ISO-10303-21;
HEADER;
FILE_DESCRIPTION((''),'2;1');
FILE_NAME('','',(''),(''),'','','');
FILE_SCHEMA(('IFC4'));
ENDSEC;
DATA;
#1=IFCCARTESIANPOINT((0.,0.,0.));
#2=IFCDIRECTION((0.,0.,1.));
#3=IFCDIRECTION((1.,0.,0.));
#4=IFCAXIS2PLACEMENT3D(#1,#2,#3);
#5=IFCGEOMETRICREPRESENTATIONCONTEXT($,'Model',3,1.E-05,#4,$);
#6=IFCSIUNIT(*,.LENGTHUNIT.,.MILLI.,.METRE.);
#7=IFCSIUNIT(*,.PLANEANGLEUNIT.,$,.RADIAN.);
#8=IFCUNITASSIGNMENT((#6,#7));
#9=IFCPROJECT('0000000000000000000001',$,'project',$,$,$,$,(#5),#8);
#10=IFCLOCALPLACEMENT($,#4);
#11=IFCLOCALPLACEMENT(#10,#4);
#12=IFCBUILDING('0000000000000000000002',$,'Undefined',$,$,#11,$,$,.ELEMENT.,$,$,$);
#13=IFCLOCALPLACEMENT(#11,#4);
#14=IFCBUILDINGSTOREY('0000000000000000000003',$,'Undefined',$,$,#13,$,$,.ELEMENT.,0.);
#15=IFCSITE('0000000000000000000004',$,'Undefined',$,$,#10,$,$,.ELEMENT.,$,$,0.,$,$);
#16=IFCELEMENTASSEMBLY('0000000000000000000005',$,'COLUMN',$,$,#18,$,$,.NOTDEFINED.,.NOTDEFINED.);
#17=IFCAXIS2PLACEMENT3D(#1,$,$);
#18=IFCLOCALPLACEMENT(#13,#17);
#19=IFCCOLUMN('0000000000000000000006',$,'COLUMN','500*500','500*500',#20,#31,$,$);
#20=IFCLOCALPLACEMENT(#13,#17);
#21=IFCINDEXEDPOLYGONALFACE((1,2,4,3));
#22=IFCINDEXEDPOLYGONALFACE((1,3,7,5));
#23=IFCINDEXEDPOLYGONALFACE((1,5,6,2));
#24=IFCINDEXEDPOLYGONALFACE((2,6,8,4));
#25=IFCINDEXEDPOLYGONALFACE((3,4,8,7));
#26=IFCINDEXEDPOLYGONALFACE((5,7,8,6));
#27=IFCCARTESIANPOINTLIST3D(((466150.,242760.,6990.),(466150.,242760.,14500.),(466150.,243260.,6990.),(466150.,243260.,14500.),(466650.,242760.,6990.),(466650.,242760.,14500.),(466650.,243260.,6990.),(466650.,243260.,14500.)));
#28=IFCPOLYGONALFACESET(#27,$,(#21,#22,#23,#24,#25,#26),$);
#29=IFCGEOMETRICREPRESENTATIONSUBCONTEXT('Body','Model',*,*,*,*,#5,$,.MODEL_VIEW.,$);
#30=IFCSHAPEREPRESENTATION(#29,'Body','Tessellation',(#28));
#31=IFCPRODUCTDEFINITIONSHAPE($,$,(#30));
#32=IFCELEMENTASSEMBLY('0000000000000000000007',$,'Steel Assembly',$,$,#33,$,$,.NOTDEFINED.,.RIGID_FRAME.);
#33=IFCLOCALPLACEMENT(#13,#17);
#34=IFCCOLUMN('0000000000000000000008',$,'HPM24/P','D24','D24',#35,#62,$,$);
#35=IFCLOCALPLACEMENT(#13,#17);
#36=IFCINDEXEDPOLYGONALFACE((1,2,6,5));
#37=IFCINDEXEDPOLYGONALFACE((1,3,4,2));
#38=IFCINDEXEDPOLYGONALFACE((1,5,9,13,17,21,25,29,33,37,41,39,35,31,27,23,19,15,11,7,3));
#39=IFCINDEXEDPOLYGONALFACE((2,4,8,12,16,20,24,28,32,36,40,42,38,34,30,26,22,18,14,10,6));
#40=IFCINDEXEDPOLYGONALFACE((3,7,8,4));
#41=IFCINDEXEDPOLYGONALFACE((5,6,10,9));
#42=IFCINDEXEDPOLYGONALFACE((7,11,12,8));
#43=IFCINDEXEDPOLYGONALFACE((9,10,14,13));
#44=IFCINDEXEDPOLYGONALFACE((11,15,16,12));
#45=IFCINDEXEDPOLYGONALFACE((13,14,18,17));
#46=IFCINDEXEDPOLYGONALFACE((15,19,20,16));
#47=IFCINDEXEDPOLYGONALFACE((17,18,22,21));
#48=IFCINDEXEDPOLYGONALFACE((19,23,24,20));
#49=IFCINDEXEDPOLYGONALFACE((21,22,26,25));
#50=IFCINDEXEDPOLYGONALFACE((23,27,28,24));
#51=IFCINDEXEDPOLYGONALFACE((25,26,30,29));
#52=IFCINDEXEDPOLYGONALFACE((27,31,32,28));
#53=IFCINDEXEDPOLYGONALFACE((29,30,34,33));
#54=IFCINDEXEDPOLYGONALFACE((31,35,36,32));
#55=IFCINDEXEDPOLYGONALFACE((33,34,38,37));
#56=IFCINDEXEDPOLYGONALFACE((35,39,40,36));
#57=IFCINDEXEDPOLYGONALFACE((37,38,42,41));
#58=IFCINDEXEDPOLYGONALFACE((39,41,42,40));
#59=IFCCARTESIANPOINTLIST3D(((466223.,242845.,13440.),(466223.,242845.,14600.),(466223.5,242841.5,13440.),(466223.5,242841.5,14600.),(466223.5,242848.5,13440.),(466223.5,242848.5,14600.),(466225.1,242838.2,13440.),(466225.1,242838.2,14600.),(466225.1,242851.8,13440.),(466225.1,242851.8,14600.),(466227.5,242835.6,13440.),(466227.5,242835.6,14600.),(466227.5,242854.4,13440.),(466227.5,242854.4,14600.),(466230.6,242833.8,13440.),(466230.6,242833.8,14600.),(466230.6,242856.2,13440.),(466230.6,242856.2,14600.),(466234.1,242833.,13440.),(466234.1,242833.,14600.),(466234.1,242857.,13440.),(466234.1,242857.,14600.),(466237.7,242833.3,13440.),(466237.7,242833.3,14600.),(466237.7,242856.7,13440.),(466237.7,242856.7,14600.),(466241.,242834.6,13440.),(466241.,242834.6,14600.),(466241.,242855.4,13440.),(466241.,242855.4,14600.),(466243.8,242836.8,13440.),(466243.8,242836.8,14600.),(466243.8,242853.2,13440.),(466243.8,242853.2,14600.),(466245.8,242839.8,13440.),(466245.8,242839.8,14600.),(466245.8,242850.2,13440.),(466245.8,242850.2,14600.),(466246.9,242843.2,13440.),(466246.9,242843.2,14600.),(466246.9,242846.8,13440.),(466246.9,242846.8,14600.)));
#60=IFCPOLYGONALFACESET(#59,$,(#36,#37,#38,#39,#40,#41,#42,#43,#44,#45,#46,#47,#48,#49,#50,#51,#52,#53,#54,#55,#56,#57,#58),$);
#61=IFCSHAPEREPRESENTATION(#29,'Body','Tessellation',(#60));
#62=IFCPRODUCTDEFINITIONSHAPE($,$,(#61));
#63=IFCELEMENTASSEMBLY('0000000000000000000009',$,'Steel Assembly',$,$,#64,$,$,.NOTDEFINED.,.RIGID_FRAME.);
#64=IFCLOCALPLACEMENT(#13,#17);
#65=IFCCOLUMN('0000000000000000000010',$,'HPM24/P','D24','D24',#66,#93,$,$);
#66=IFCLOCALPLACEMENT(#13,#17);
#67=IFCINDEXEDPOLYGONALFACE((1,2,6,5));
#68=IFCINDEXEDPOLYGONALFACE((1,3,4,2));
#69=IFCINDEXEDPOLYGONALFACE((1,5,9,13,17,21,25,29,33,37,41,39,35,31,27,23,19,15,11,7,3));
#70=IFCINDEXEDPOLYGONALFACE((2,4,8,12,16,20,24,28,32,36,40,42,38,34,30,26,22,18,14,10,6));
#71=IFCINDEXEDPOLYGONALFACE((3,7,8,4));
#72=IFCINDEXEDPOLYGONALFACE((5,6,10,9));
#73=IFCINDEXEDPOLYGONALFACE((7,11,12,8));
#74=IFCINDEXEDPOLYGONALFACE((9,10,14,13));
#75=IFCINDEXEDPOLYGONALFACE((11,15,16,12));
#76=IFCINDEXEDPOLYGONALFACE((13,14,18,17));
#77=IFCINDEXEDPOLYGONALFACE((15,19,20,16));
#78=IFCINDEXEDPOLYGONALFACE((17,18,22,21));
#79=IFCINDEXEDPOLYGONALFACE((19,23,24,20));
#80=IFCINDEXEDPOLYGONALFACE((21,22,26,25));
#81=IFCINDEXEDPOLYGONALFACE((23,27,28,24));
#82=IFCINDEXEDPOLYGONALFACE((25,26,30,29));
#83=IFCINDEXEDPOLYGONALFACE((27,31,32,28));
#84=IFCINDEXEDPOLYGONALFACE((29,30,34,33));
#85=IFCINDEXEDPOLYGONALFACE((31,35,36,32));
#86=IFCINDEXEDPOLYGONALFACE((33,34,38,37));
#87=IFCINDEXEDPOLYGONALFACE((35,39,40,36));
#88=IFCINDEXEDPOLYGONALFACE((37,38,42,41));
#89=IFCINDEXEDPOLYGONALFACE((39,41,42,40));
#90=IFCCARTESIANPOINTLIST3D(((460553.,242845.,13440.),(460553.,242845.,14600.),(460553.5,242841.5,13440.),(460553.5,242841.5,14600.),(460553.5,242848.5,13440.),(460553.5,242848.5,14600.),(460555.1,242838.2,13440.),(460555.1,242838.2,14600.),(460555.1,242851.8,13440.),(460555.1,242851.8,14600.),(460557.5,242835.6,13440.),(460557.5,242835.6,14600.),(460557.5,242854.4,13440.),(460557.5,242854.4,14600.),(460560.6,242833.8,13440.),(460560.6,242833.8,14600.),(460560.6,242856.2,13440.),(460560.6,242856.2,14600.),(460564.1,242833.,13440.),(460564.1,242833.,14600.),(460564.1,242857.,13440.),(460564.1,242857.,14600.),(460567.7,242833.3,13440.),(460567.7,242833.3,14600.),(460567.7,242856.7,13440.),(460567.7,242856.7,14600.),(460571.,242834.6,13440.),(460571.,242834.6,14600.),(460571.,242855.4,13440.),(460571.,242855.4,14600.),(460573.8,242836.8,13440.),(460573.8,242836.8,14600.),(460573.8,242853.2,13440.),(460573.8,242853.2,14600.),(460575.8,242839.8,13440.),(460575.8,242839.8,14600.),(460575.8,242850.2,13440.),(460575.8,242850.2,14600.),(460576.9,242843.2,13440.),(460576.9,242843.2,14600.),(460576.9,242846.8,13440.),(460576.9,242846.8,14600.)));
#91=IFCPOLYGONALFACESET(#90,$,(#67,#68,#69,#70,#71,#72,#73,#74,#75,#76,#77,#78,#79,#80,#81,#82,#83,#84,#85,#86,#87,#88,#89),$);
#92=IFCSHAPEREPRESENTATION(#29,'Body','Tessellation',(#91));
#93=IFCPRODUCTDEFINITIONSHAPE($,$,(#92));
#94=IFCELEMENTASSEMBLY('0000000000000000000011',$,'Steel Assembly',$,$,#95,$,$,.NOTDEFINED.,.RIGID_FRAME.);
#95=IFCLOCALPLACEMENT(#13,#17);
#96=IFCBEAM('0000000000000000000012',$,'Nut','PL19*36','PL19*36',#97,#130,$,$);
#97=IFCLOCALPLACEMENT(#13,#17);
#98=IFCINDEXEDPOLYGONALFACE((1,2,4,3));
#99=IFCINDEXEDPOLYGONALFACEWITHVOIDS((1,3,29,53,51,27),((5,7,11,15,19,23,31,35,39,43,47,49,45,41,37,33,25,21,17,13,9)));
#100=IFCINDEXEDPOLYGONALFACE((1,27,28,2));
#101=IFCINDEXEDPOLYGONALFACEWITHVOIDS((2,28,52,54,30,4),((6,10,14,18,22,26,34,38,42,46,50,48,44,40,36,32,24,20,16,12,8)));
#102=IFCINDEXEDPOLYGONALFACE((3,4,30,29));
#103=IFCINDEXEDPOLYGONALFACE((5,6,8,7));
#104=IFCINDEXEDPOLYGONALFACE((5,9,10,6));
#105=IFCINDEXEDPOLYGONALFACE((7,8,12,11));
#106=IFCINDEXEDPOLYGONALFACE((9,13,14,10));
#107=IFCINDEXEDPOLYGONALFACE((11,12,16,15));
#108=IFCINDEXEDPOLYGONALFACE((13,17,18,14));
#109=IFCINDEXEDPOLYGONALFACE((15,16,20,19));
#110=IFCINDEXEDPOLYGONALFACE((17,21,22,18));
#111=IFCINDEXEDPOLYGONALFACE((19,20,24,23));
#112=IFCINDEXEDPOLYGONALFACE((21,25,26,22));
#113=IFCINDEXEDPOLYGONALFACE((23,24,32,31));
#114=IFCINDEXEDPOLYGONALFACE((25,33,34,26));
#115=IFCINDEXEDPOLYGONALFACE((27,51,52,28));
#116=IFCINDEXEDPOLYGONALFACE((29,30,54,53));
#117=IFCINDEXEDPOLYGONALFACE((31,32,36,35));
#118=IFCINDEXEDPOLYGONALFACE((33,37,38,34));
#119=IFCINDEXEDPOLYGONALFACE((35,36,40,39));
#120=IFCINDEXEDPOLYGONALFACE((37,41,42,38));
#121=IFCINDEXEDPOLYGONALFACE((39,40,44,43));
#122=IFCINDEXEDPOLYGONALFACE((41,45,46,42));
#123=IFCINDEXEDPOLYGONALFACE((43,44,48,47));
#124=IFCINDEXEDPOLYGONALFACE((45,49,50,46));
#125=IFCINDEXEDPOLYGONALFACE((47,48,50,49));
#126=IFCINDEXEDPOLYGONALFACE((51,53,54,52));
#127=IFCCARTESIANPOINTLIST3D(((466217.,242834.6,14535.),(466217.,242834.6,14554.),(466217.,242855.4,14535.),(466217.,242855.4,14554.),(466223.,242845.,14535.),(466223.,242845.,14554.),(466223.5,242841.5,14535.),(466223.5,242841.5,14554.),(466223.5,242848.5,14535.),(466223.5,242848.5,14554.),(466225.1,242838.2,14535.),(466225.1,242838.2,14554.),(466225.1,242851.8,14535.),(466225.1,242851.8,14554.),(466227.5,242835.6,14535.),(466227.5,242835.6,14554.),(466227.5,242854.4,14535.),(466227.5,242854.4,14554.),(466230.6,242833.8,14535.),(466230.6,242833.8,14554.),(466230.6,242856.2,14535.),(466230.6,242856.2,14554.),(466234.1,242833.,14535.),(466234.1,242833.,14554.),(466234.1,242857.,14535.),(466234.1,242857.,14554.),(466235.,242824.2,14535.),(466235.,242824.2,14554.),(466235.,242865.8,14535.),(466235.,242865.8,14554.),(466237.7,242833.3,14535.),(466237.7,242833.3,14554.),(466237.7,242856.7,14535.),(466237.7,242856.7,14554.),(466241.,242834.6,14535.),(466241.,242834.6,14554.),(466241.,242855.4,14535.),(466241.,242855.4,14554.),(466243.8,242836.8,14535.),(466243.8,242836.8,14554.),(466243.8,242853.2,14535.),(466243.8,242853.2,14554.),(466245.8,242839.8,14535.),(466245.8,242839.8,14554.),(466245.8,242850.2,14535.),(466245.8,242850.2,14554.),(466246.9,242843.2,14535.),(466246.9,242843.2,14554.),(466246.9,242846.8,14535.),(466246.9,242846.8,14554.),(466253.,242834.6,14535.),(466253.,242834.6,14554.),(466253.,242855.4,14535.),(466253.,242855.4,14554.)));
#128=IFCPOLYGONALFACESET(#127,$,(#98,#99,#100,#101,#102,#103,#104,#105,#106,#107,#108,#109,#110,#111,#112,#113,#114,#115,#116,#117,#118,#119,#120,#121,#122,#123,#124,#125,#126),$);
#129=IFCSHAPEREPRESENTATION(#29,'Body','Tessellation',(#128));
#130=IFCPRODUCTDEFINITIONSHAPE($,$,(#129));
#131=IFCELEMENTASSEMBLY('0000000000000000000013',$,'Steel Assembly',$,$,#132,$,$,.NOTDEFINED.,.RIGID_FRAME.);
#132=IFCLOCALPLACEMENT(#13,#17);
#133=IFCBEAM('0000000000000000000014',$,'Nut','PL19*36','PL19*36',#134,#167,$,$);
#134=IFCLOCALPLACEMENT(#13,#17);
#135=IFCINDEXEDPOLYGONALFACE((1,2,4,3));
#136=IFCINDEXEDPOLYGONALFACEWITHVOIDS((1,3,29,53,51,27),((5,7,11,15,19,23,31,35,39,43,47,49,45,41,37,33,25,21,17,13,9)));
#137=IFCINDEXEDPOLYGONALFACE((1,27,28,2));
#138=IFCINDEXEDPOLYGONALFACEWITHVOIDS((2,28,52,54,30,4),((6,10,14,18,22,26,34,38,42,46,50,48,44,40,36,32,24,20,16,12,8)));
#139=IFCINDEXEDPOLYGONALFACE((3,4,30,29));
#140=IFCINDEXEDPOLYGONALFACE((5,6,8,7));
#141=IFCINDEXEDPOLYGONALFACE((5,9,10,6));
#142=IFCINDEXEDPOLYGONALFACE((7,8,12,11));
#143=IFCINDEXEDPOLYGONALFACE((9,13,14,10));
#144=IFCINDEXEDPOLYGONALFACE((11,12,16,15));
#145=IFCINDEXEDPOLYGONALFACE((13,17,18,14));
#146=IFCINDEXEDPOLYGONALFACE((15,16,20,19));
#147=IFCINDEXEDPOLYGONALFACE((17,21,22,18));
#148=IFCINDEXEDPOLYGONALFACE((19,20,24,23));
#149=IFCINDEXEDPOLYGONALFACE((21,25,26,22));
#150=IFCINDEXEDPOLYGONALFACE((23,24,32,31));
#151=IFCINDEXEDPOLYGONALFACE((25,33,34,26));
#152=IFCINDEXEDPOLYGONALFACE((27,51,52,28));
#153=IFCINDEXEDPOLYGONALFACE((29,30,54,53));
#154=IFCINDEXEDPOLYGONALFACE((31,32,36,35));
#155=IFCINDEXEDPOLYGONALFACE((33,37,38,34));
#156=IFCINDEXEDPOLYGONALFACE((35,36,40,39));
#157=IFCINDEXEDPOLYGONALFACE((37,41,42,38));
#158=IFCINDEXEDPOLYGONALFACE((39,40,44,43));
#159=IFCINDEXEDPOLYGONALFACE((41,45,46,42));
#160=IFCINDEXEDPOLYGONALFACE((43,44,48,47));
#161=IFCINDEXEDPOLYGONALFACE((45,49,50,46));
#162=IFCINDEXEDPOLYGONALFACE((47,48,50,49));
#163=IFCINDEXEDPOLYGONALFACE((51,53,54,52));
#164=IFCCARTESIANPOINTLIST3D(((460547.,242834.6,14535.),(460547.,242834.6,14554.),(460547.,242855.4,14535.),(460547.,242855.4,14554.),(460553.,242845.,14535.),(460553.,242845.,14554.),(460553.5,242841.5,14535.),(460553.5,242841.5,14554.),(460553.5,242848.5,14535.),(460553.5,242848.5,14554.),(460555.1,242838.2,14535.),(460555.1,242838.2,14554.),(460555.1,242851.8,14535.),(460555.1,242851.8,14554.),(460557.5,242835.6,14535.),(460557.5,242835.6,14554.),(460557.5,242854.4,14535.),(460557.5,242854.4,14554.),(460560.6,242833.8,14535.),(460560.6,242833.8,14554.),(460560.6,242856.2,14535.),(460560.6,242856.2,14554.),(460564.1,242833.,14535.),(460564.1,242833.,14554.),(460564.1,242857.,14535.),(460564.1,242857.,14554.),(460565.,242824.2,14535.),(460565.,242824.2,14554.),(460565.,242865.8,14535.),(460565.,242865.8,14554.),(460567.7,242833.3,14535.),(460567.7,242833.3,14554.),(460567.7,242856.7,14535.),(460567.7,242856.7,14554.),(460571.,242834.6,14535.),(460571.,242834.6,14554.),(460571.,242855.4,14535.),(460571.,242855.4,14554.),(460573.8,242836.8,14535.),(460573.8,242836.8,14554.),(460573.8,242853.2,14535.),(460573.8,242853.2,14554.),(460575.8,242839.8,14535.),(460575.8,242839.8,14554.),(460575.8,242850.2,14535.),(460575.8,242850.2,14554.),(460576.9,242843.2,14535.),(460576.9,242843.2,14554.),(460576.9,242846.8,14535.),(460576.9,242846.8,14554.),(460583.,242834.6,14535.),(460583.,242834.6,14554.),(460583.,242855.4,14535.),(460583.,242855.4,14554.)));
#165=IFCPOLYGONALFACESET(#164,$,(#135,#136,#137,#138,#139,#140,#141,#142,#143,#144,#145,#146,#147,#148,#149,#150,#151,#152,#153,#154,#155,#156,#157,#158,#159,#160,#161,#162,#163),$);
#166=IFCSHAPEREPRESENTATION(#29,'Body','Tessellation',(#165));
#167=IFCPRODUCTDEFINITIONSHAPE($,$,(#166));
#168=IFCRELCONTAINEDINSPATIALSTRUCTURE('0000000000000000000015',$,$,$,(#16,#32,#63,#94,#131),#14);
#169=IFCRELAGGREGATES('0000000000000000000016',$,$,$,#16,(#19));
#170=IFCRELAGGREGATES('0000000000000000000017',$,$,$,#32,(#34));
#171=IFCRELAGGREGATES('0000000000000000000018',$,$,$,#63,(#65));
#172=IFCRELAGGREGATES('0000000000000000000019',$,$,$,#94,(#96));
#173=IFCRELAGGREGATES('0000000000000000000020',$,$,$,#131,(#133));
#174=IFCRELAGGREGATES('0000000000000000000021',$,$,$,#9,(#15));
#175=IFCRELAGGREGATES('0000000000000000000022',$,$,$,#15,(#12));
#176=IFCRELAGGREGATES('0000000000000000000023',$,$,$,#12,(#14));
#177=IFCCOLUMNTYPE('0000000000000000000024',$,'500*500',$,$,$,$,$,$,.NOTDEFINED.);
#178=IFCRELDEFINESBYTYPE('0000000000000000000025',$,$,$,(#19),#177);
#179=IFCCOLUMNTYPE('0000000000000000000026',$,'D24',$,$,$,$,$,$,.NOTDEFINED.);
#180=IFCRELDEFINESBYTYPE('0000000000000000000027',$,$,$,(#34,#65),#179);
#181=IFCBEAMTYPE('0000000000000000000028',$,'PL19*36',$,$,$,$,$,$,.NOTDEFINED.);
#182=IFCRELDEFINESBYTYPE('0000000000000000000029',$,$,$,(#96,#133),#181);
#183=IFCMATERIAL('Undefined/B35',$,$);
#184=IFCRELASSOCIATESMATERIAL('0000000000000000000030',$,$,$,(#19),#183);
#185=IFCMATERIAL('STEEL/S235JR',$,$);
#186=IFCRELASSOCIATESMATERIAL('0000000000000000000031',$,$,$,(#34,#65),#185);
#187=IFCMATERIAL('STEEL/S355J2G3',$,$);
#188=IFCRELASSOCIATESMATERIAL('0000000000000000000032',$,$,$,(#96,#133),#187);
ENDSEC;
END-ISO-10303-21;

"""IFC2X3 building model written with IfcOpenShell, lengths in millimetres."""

from ifc_helpers import new_model, si_unit, frame, origin_with_axes, origin_2d_with_axis, place, context, subcontext, project, spatial, rectangle, circle, extrude, boolean, halfspace, material, type_object, element, aggregate, save


model = new_model("IFC2X3")

# Units and contexts
model_context = context("Model", 3, precision=1e-05, world=origin_with_axes())
body_context = subcontext(model_context, "Body", "Model", "MODEL_VIEW")
ifc_project = project(units=[si_unit("LENGTHUNIT", "METRE", prefix="MILLI"), si_unit("PLANEANGLEUNIT", "RADIAN")], contexts=[model_context])

# Site, building, storey
site_placement = place(None, origin_with_axes())
site = spatial("IfcSite", under=ifc_project, at=site_placement, Name="Undefined", CompositionType="ELEMENT", RefElevation=0.0)
building_placement = place(site_placement, origin_with_axes())
building = spatial("IfcBuilding", under=site, at=building_placement, Name="Undefined", CompositionType="ELEMENT")
storey_placement = place(building_placement, origin_with_axes())
storey = spatial("IfcBuildingStorey", under=building, at=storey_placement, Name="Undefined", CompositionType="ELEMENT", Elevation=0.0)

# Element assemblies, columns
assembly_1_placement = place(storey_placement, origin_with_axes())
assembly_1 = element("IfcElementAssembly", 1, at=assembly_1_placement, inside=storey, Name="COLUMN", AssemblyPlace="NOTDEFINED", PredefinedType="NOTDEFINED")
ifc_material_1 = material(Name="Undefined/B35")
column_type_1 = type_object("IfcColumnType", Name="500*500", PredefinedType="NOTDEFINED")
column_1_placement = place(assembly_1_placement, frame((466400.0, 243010.0, 6990.0), z_axis=(0.0, 0.0, 1.0), x_axis=(1.0, 0.0, 0.0)))
column_1 = element("IfcColumn", 2, at=column_1_placement, type_object=column_type_1, material=ifc_material_1, Name="COLUMN", Description="500*500", ObjectType="500*500", context=body_context, shape_type="SweptSolid", body=[
    extrude(rectangle(XDim=500.0, YDim=500.0, at=origin_2d_with_axis()), frame((0.0, 0.0, 7510.0), z_axis=(0.0, 0.0, -1.0), x_axis=(-1.0, 0.0, 0.0)), (0.0, 0.0, 1.0), 7510.0),
])
aggregate(assembly_1, [column_1])
assembly_2_placement = place(storey_placement, origin_with_axes())
assembly_2 = element("IfcElementAssembly", 3, at=assembly_2_placement, inside=storey, Name="Steel Assembly", AssemblyPlace="NOTDEFINED", PredefinedType="RIGID_FRAME")
ifc_material_2 = material(Name="STEEL/S235JR")
column_type_2 = type_object("IfcColumnType", Name="D24", PredefinedType="NOTDEFINED")
column_2_placement = place(assembly_2_placement, frame((466235.0, 242845.0, 13440.0), z_axis=(0.0, 0.0, 1.0), x_axis=(1.0, 0.0, 0.0)))
column_2 = element("IfcColumn", 4, at=column_2_placement, type_object=column_type_2, material=ifc_material_2, Name="HPM24/P", Description="D24", ObjectType="D24", context=body_context, shape_type="SweptSolid", body=[
    extrude(circle(Radius=12.0, at=origin_2d_with_axis()), frame((0.0, 0.0, 1160.0), z_axis=(0.0, 0.0, -1.0), x_axis=(-1.0, 0.0, 0.0)), (0.0, 0.0, 1.0), 1160.0),
])
aggregate(assembly_2, [column_2])
assembly_3_placement = place(storey_placement, origin_with_axes())
assembly_3 = element("IfcElementAssembly", 5, at=assembly_3_placement, inside=storey, Name="Steel Assembly", AssemblyPlace="NOTDEFINED", PredefinedType="RIGID_FRAME")
column_3_placement = place(assembly_3_placement, frame((460565.0, 242845.0, 13440.0), z_axis=(0.0, 0.0, 1.0), x_axis=(1.0, 0.0, 0.0)))
column_3 = element("IfcColumn", 6, at=column_3_placement, type_object=column_type_2, material=ifc_material_2, Name="HPM24/P", Description="D24", ObjectType="D24", context=body_context, shape_type="SweptSolid", body=[
    extrude(circle(Radius=12.0, at=origin_2d_with_axis()), frame((0.0, 0.0, 1160.0), z_axis=(0.0, 0.0, -1.0), x_axis=(-1.0, 0.0, 0.0)), (0.0, 0.0, 1.0), 1160.0),
])
aggregate(assembly_3, [column_3])

# Element assemblies, beams
assembly_4_placement = place(storey_placement, origin_with_axes())
assembly_4 = element("IfcElementAssembly", 7, at=assembly_4_placement, inside=storey, Name="Steel Assembly", AssemblyPlace="NOTDEFINED", PredefinedType="RIGID_FRAME")
ifc_material_3 = material(Name="STEEL/S355J2G3")
beam_type_1 = type_object("IfcBeamType", Name="PL19*36", PredefinedType="NOTDEFINED")
beam_1_placement = place(assembly_4_placement, frame((466235.0, 242865.8, 14544.5), z_axis=(-1.0, 0.0, 0.0), x_axis=(0.0, -1.0, 0.0)))
beam_1 = element("IfcBeam", 8, at=beam_1_placement, type_object=beam_type_1, material=ifc_material_3, Name="Nut", Description="PL19*36", ObjectType="PL19*36", context=body_context, shape_type="CSG", body=[
    boolean("DIFFERENCE", boolean("DIFFERENCE", boolean("DIFFERENCE", boolean("DIFFERENCE", boolean("DIFFERENCE", extrude(rectangle(XDim=19.0, YDim=36.0, at=origin_2d_with_axis()), frame((41.6, 0.0, 0.0), z_axis=(-1.0, 0.0, 0.0), x_axis=(0.0, -1.0, 0.0)), (0.0, 0.0, 1.0), 41.6), extrude(circle(Radius=12.0, at=origin_2d_with_axis()), frame((20.8, -9.5, 0.0), z_axis=(0.0, 1.0, 0.0), x_axis=(0.0, 0.0, 1.0)), (0.0, 0.0, 1.0), 19.0)), halfspace(frame((31.2, -9.5, -18.0), z_axis=(0.865865, 0.0, -0.500278), x_axis=(0.500278, 0.0, 0.865865)), False)), halfspace(frame((52.0, -9.5, -18.0), z_axis=(0.865865, 0.0, 0.500278), x_axis=(-0.500278, 0.0, 0.865865)), False)), halfspace(frame((-10.4, 9.5, -18.0), z_axis=(-0.865865, 0.0, 0.500278), x_axis=(0.500278, 0.0, 0.865865)), False)), halfspace(frame((10.4, 9.5, -18.0), z_axis=(-0.865865, 0.0, -0.500278), x_axis=(-0.500278, 0.0, 0.865865)), False)),
])
aggregate(assembly_4, [beam_1])
assembly_5_placement = place(storey_placement, origin_with_axes())
assembly_5 = element("IfcElementAssembly", 9, at=assembly_5_placement, inside=storey, Name="Steel Assembly", AssemblyPlace="NOTDEFINED", PredefinedType="RIGID_FRAME")
beam_2_placement = place(assembly_5_placement, frame((460565.0, 242865.8, 14544.5), z_axis=(-1.0, 0.0, 0.0), x_axis=(0.0, -1.0, 0.0)))
beam_2 = element("IfcBeam", 10, at=beam_2_placement, type_object=beam_type_1, material=ifc_material_3, Name="Nut", Description="PL19*36", ObjectType="PL19*36", context=body_context, shape_type="CSG", body=[
    boolean("DIFFERENCE", boolean("DIFFERENCE", boolean("DIFFERENCE", boolean("DIFFERENCE", boolean("DIFFERENCE", extrude(rectangle(XDim=19.0, YDim=36.0, at=origin_2d_with_axis()), frame((41.6, 0.0, 0.0), z_axis=(-1.0, 0.0, 0.0), x_axis=(0.0, -1.0, 0.0)), (0.0, 0.0, 1.0), 41.6), extrude(circle(Radius=12.0, at=origin_2d_with_axis()), frame((20.8, -9.5, 0.0), z_axis=(0.0, 1.0, 0.0), x_axis=(0.0, 0.0, 1.0)), (0.0, 0.0, 1.0), 19.0)), halfspace(frame((31.2, -9.5, -18.0), z_axis=(0.865865, 0.0, -0.500278), x_axis=(0.500278, 0.0, 0.865865)), False)), halfspace(frame((52.0, -9.5, -18.0), z_axis=(0.865865, 0.0, 0.500278), x_axis=(-0.500278, 0.0, 0.865865)), False)), halfspace(frame((-10.4, 9.5, -18.0), z_axis=(-0.865865, 0.0, 0.500278), x_axis=(0.500278, 0.0, 0.865865)), False)), halfspace(frame((10.4, 9.5, -18.0), z_axis=(-0.865865, 0.0, -0.500278), x_axis=(-0.500278, 0.0, 0.865865)), False)),
])
aggregate(assembly_5, [beam_2])

save(model, "model.ifc")
